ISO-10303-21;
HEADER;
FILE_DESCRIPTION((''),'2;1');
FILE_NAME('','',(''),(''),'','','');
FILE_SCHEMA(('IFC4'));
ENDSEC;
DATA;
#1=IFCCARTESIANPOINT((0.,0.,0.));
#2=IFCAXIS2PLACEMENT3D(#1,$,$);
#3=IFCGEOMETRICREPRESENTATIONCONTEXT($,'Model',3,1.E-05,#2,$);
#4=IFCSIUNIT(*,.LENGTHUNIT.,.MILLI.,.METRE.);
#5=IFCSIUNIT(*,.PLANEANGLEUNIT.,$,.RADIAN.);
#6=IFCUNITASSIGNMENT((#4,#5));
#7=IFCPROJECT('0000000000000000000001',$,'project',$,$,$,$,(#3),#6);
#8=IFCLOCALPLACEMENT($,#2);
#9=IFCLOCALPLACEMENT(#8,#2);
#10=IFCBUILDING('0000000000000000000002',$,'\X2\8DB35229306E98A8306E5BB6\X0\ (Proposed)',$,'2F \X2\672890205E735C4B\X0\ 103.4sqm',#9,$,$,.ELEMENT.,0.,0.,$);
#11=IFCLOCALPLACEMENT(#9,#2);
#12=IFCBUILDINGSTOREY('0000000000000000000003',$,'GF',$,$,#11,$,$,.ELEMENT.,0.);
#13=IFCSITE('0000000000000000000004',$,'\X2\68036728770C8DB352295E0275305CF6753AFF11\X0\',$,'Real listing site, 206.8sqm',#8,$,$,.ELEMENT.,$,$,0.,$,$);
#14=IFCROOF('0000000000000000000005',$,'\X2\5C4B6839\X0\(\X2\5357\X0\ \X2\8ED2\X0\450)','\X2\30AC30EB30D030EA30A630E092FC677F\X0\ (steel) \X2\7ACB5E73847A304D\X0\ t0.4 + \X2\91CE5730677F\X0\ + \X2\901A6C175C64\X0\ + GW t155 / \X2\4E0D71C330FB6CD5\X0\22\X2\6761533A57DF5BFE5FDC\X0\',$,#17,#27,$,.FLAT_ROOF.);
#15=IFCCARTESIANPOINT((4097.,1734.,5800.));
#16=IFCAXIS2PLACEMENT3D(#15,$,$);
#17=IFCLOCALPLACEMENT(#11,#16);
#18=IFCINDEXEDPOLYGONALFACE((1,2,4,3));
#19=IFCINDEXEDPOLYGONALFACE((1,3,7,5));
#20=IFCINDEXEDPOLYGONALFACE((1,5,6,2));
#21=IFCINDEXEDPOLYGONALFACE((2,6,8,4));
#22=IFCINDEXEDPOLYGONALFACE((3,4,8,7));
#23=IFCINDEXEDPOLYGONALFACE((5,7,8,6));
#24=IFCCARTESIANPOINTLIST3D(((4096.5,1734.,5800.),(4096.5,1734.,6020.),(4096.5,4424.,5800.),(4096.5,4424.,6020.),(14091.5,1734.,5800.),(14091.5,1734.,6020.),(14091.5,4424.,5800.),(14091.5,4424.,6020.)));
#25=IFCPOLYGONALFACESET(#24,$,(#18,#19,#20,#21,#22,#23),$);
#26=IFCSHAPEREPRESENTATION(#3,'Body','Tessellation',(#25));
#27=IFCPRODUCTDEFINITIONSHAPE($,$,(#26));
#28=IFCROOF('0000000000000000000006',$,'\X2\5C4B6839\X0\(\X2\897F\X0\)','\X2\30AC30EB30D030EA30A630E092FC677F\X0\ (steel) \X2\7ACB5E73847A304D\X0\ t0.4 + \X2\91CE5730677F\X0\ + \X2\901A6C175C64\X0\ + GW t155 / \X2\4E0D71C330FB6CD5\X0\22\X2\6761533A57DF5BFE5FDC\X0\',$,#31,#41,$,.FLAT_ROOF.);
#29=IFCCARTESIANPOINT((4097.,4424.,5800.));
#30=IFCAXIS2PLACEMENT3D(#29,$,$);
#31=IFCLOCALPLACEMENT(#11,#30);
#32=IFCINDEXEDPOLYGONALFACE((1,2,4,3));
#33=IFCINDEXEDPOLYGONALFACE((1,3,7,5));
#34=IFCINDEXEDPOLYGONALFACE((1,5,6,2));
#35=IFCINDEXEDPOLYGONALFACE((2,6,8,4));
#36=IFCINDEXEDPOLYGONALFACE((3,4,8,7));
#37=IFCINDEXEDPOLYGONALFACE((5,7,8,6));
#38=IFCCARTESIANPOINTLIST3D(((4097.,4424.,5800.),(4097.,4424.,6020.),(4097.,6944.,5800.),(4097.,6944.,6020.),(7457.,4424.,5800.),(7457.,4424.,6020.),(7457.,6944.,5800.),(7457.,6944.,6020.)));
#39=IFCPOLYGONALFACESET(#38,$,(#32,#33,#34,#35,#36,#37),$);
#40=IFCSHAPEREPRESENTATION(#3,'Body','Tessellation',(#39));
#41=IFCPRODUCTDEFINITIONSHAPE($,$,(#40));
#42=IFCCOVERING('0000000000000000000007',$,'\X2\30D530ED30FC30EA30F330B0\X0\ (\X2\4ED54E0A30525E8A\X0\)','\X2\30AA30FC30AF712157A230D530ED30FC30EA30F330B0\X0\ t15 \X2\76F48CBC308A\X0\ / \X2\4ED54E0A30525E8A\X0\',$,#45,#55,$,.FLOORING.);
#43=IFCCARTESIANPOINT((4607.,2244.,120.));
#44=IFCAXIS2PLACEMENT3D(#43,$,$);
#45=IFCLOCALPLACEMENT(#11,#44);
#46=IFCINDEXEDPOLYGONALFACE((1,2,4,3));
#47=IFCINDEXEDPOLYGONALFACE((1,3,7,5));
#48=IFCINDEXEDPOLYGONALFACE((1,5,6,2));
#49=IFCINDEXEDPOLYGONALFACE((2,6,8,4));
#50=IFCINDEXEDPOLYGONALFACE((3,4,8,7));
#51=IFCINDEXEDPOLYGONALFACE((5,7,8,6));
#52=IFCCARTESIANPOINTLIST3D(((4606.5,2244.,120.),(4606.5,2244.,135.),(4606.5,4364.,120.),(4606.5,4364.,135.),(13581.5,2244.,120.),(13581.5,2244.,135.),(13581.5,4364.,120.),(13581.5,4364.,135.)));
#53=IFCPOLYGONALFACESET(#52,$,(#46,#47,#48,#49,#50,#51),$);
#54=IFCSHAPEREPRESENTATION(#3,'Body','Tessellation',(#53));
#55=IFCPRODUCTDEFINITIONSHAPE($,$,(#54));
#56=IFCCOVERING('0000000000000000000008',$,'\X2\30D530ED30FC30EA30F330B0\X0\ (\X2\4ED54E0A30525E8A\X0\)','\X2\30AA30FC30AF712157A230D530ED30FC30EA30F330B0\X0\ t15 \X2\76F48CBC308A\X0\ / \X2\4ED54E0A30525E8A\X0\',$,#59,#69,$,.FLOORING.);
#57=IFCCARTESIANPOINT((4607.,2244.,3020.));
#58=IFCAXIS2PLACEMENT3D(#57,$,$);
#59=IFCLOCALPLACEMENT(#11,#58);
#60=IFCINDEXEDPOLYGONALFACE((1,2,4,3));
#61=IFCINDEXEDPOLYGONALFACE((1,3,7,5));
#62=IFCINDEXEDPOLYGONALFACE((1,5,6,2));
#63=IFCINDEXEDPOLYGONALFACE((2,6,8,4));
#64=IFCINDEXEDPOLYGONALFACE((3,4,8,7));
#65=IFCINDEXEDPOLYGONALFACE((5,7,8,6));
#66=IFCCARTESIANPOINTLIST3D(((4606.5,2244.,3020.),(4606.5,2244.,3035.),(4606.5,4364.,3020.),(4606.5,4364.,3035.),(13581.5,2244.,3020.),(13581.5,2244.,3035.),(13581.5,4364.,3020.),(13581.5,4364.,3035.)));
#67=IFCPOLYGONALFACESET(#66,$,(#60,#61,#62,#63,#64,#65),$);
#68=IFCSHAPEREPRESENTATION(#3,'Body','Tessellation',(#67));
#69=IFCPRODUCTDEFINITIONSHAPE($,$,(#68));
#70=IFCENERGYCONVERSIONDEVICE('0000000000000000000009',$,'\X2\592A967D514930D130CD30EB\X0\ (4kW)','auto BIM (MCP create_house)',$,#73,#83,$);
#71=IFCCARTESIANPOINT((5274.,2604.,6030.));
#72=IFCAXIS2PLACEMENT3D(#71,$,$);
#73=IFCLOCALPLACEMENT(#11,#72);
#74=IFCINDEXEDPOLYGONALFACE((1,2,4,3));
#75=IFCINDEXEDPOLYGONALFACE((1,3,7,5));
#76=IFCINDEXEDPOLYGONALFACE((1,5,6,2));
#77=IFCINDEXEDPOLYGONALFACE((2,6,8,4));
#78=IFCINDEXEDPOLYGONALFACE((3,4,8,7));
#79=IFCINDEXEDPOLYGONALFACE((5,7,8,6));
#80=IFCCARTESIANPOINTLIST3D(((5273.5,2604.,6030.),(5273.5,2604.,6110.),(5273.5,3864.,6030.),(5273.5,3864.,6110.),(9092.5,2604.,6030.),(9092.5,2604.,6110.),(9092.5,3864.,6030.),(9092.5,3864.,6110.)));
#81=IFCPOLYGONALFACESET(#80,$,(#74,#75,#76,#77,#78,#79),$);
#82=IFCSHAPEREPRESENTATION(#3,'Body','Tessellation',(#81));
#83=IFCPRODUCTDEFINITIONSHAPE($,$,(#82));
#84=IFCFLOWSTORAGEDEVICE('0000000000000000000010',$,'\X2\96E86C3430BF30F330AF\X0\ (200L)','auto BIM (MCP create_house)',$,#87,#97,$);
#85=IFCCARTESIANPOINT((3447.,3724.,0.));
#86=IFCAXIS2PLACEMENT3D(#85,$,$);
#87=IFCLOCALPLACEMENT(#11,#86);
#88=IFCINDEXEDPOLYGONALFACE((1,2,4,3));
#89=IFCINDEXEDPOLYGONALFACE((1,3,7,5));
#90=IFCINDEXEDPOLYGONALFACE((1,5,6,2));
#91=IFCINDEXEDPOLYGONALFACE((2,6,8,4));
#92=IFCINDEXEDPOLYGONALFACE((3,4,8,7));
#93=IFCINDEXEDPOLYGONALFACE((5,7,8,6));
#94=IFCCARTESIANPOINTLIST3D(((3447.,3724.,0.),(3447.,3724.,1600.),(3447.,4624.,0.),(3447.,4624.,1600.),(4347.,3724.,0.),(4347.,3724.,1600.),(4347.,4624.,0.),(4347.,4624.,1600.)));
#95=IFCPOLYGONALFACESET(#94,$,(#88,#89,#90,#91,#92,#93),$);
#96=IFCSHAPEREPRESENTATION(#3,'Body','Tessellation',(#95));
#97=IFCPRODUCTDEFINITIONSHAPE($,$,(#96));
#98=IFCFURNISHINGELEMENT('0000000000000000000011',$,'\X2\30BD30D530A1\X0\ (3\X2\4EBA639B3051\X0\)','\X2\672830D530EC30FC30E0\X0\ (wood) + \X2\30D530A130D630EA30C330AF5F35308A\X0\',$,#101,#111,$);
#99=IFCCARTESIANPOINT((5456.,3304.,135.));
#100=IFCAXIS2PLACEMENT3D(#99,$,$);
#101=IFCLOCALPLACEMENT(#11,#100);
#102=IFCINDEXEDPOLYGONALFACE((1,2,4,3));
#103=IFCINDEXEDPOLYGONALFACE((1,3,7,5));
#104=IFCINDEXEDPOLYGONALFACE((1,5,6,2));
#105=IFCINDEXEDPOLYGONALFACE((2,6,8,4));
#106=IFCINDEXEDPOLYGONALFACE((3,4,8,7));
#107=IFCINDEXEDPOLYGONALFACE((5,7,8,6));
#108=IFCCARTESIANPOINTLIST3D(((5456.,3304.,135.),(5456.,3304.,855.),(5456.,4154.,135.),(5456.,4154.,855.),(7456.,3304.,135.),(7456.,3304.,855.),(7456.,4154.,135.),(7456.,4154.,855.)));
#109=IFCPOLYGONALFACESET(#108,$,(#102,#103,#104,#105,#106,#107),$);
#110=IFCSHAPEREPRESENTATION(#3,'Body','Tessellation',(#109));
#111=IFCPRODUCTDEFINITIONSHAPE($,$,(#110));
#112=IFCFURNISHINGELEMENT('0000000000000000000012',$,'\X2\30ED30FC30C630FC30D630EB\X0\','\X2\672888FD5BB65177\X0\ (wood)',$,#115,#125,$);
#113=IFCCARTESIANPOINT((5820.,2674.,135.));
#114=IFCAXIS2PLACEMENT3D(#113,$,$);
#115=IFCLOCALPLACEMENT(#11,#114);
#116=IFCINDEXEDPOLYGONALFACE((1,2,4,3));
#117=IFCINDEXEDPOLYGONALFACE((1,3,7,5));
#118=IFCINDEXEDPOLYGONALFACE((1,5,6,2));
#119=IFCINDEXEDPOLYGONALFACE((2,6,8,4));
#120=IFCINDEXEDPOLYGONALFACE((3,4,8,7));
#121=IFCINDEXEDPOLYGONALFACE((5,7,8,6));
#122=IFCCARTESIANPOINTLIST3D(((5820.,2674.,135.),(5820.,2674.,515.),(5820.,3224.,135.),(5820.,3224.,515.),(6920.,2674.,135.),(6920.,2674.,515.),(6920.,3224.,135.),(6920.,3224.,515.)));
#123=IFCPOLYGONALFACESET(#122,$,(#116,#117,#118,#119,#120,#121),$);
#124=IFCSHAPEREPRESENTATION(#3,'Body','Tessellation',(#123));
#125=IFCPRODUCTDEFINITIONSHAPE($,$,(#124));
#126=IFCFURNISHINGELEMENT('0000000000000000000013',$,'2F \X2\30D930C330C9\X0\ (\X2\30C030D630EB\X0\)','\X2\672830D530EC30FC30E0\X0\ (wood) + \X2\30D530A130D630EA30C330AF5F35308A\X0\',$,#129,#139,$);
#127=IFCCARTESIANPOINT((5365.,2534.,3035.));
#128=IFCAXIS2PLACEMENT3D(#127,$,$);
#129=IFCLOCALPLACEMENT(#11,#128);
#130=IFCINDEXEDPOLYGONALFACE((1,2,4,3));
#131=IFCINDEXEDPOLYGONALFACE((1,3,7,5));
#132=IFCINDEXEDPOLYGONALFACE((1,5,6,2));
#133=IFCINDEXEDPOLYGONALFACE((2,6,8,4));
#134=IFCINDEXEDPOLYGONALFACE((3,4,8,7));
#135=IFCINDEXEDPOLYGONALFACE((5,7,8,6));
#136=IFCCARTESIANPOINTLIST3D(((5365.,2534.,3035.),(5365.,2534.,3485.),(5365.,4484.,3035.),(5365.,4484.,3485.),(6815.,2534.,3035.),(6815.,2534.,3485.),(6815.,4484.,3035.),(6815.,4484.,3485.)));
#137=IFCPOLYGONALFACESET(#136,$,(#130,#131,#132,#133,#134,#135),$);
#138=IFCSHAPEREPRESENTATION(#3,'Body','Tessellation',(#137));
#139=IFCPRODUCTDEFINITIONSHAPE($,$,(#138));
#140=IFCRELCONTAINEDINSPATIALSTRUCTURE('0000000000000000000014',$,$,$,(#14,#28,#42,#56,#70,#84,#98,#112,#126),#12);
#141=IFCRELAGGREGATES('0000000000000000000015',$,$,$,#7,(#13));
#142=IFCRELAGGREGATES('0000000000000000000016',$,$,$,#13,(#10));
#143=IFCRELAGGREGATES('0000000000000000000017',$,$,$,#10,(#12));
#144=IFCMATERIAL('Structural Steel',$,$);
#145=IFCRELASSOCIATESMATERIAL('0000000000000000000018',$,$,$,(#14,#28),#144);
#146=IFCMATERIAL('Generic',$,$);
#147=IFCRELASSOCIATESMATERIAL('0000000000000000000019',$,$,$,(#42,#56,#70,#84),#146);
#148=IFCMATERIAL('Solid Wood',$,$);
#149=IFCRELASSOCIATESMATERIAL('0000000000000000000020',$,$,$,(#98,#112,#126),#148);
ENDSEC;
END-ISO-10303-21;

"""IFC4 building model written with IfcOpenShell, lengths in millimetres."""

from ifc_helpers import new_model, si_unit, frame, frame_2d, origin, place, context, project, spatial, rectangle, extrude, material, element, save


model = new_model("IFC4")

# Units and contexts
model_context = context("Model", 3, precision=1e-05, world=origin())
ifc_project = project(units=[si_unit("LENGTHUNIT", "METRE", prefix="MILLI"), si_unit("PLANEANGLEUNIT", "RADIAN")], contexts=[model_context])

# Site, building, storey
site_placement = place(None, origin())
site = spatial("IfcSite", under=ifc_project, at=site_placement, Name="栃木県足利市田島町１", ObjectType="Real listing site, 206.8sqm", CompositionType="ELEMENT", RefElevation=0.0)
building_placement = place(site_placement, origin())
building = spatial("IfcBuilding", under=site, at=building_placement, Name="足利の風の家 (Proposed)", ObjectType="2F 木造平屋 103.4sqm", CompositionType="ELEMENT", ElevationOfRefHeight=0.0, ElevationOfTerrain=0.0)
storey_placement = place(building_placement, origin())
storey = spatial("IfcBuildingStorey", under=building, at=storey_placement, Name="GF", CompositionType="ELEMENT", Elevation=0.0)

# Shared definitions
ifc_material_1 = material(Name="Solid Wood")

# Roofs
ifc_material_2 = material(Name="Structural Steel")
roof_1_placement = place(storey_placement, frame((4097.0, 1734.0, 5800.0)))
element("IfcRoof", 1, at=roof_1_placement, inside=storey, material=ifc_material_2, Name="屋根(南 軒450)", Description="ガルバリウム鋼板 (steel) 立平葺き t0.4 + 野地板 + 通気層 + GW t155 / 不燃・法22条区域対応", PredefinedType="FLAT_ROOF", context=model_context, shape_type="SweptSolid", body=[
    extrude(rectangle(XDim=9995.0, YDim=2690.0, at=frame_2d((4997.0, 1345.0))), frame((4097.0, 1734.0, 5800.0)), (0.0, 0.0, 1.0), 220.0),
])
roof_2_placement = place(storey_placement, frame((4097.0, 4424.0, 5800.0)))
element("IfcRoof", 2, at=roof_2_placement, inside=storey, material=ifc_material_2, Name="屋根(西)", Description="ガルバリウム鋼板 (steel) 立平葺き t0.4 + 野地板 + 通気層 + GW t155 / 不燃・法22条区域対応", PredefinedType="FLAT_ROOF", context=model_context, shape_type="SweptSolid", body=[
    extrude(rectangle(XDim=3360.0, YDim=2520.0, at=frame_2d((1680.0, 1260.0))), frame((4097.0, 4424.0, 5800.0)), (0.0, 0.0, 1.0), 220.0),
])

# Coverings
ifc_material_3 = material(Name="Generic")
covering_1_placement = place(storey_placement, frame((4607.0, 2244.0, 120.0)))
element("IfcCovering", 3, at=covering_1_placement, inside=storey, material=ifc_material_3, Name="フローリング (仕上げ床)", Description="オーク無垢フローリング t15 直貼り / 仕上げ床", PredefinedType="FLOORING", context=model_context, shape_type="SweptSolid", body=[
    extrude(rectangle(XDim=8975.0, YDim=2120.0, at=frame_2d((4487.0, 1060.0))), frame((4607.0, 2244.0, 120.0)), (0.0, 0.0, 1.0), 15.0),
])
covering_2_placement = place(storey_placement, frame((4607.0, 2244.0, 3020.0)))
element("IfcCovering", 4, at=covering_2_placement, inside=storey, material=ifc_material_3, Name="フローリング (仕上げ床)", Description="オーク無垢フローリング t15 直貼り / 仕上げ床", PredefinedType="FLOORING", context=model_context, shape_type="SweptSolid", body=[
    extrude(rectangle(XDim=8975.0, YDim=2120.0, at=frame_2d((4487.0, 1060.0))), frame((4607.0, 2244.0, 3020.0)), (0.0, 0.0, 1.0), 15.0),
])

# Energy conversion device
energy_conversion_device_placement = place(storey_placement, frame((5274.0, 2604.0, 6030.0)))
element("IfcEnergyConversionDevice", 5, at=energy_conversion_device_placement, inside=storey, material=ifc_material_3, Name="太陽光パネル (4kW)", Description="auto BIM (MCP create_house)", context=model_context, shape_type="SweptSolid", body=[
    extrude(rectangle(XDim=3819.0, YDim=1260.0, at=frame_2d((1909.0, 630.0))), frame((5274.0, 2604.0, 6030.0)), (0.0, 0.0, 1.0), 80.0),
])

# Flow storage device
flow_storage_device_placement = place(storey_placement, frame((3447.0, 3724.0, 0.0)))
element("IfcFlowStorageDevice", 6, at=flow_storage_device_placement, inside=storey, material=ifc_material_3, Name="雨水タンク (200L)", Description="auto BIM (MCP create_house)", context=model_context, shape_type="SweptSolid", body=[
    extrude(rectangle(XDim=900.0, YDim=900.0, at=frame_2d((450.0, 450.0))), frame((3447.0, 3724.0, 0.0)), (0.0, 0.0, 1.0), 1600.0),
])

# Furnishing elements
furnishing_1_placement = place(storey_placement, frame((5456.0, 3304.0, 135.0)))
element("IfcFurnishingElement", 7, at=furnishing_1_placement, inside=storey, material=ifc_material_1, Name="ソファ (3人掛け)", Description="木フレーム (wood) + ファブリック張り", context=model_context, shape_type="SweptSolid", body=[
    extrude(rectangle(XDim=2000.0, YDim=850.0, at=frame_2d((1000.0, 425.0))), frame((5456.0, 3304.0, 135.0)), (0.0, 0.0, 1.0), 720.0),
])
furnishing_2_placement = place(storey_placement, frame((5820.0, 2674.0, 135.0)))
element("IfcFurnishingElement", 8, at=furnishing_2_placement, inside=storey, material=ifc_material_1, Name="ローテーブル", Description="木製家具 (wood)", context=model_context, shape_type="SweptSolid", body=[
    extrude(rectangle(XDim=1100.0, YDim=550.0, at=frame_2d((550.0, 275.0))), frame((5820.0, 2674.0, 135.0)), (0.0, 0.0, 1.0), 380.0),
])
furnishing_3_placement = place(storey_placement, frame((5365.0, 2534.0, 3035.0)))
element("IfcFurnishingElement", 9, at=furnishing_3_placement, inside=storey, material=ifc_material_1, Name="2F ベッド (ダブル)", Description="木フレーム (wood) + ファブリック張り", context=model_context, shape_type="SweptSolid", body=[
    extrude(rectangle(XDim=1450.0, YDim=1950.0, at=frame_2d((725.0, 975.0))), frame((5365.0, 2534.0, 3035.0)), (0.0, 0.0, 1.0), 450.0),
])

save(model, "model.ifc")
